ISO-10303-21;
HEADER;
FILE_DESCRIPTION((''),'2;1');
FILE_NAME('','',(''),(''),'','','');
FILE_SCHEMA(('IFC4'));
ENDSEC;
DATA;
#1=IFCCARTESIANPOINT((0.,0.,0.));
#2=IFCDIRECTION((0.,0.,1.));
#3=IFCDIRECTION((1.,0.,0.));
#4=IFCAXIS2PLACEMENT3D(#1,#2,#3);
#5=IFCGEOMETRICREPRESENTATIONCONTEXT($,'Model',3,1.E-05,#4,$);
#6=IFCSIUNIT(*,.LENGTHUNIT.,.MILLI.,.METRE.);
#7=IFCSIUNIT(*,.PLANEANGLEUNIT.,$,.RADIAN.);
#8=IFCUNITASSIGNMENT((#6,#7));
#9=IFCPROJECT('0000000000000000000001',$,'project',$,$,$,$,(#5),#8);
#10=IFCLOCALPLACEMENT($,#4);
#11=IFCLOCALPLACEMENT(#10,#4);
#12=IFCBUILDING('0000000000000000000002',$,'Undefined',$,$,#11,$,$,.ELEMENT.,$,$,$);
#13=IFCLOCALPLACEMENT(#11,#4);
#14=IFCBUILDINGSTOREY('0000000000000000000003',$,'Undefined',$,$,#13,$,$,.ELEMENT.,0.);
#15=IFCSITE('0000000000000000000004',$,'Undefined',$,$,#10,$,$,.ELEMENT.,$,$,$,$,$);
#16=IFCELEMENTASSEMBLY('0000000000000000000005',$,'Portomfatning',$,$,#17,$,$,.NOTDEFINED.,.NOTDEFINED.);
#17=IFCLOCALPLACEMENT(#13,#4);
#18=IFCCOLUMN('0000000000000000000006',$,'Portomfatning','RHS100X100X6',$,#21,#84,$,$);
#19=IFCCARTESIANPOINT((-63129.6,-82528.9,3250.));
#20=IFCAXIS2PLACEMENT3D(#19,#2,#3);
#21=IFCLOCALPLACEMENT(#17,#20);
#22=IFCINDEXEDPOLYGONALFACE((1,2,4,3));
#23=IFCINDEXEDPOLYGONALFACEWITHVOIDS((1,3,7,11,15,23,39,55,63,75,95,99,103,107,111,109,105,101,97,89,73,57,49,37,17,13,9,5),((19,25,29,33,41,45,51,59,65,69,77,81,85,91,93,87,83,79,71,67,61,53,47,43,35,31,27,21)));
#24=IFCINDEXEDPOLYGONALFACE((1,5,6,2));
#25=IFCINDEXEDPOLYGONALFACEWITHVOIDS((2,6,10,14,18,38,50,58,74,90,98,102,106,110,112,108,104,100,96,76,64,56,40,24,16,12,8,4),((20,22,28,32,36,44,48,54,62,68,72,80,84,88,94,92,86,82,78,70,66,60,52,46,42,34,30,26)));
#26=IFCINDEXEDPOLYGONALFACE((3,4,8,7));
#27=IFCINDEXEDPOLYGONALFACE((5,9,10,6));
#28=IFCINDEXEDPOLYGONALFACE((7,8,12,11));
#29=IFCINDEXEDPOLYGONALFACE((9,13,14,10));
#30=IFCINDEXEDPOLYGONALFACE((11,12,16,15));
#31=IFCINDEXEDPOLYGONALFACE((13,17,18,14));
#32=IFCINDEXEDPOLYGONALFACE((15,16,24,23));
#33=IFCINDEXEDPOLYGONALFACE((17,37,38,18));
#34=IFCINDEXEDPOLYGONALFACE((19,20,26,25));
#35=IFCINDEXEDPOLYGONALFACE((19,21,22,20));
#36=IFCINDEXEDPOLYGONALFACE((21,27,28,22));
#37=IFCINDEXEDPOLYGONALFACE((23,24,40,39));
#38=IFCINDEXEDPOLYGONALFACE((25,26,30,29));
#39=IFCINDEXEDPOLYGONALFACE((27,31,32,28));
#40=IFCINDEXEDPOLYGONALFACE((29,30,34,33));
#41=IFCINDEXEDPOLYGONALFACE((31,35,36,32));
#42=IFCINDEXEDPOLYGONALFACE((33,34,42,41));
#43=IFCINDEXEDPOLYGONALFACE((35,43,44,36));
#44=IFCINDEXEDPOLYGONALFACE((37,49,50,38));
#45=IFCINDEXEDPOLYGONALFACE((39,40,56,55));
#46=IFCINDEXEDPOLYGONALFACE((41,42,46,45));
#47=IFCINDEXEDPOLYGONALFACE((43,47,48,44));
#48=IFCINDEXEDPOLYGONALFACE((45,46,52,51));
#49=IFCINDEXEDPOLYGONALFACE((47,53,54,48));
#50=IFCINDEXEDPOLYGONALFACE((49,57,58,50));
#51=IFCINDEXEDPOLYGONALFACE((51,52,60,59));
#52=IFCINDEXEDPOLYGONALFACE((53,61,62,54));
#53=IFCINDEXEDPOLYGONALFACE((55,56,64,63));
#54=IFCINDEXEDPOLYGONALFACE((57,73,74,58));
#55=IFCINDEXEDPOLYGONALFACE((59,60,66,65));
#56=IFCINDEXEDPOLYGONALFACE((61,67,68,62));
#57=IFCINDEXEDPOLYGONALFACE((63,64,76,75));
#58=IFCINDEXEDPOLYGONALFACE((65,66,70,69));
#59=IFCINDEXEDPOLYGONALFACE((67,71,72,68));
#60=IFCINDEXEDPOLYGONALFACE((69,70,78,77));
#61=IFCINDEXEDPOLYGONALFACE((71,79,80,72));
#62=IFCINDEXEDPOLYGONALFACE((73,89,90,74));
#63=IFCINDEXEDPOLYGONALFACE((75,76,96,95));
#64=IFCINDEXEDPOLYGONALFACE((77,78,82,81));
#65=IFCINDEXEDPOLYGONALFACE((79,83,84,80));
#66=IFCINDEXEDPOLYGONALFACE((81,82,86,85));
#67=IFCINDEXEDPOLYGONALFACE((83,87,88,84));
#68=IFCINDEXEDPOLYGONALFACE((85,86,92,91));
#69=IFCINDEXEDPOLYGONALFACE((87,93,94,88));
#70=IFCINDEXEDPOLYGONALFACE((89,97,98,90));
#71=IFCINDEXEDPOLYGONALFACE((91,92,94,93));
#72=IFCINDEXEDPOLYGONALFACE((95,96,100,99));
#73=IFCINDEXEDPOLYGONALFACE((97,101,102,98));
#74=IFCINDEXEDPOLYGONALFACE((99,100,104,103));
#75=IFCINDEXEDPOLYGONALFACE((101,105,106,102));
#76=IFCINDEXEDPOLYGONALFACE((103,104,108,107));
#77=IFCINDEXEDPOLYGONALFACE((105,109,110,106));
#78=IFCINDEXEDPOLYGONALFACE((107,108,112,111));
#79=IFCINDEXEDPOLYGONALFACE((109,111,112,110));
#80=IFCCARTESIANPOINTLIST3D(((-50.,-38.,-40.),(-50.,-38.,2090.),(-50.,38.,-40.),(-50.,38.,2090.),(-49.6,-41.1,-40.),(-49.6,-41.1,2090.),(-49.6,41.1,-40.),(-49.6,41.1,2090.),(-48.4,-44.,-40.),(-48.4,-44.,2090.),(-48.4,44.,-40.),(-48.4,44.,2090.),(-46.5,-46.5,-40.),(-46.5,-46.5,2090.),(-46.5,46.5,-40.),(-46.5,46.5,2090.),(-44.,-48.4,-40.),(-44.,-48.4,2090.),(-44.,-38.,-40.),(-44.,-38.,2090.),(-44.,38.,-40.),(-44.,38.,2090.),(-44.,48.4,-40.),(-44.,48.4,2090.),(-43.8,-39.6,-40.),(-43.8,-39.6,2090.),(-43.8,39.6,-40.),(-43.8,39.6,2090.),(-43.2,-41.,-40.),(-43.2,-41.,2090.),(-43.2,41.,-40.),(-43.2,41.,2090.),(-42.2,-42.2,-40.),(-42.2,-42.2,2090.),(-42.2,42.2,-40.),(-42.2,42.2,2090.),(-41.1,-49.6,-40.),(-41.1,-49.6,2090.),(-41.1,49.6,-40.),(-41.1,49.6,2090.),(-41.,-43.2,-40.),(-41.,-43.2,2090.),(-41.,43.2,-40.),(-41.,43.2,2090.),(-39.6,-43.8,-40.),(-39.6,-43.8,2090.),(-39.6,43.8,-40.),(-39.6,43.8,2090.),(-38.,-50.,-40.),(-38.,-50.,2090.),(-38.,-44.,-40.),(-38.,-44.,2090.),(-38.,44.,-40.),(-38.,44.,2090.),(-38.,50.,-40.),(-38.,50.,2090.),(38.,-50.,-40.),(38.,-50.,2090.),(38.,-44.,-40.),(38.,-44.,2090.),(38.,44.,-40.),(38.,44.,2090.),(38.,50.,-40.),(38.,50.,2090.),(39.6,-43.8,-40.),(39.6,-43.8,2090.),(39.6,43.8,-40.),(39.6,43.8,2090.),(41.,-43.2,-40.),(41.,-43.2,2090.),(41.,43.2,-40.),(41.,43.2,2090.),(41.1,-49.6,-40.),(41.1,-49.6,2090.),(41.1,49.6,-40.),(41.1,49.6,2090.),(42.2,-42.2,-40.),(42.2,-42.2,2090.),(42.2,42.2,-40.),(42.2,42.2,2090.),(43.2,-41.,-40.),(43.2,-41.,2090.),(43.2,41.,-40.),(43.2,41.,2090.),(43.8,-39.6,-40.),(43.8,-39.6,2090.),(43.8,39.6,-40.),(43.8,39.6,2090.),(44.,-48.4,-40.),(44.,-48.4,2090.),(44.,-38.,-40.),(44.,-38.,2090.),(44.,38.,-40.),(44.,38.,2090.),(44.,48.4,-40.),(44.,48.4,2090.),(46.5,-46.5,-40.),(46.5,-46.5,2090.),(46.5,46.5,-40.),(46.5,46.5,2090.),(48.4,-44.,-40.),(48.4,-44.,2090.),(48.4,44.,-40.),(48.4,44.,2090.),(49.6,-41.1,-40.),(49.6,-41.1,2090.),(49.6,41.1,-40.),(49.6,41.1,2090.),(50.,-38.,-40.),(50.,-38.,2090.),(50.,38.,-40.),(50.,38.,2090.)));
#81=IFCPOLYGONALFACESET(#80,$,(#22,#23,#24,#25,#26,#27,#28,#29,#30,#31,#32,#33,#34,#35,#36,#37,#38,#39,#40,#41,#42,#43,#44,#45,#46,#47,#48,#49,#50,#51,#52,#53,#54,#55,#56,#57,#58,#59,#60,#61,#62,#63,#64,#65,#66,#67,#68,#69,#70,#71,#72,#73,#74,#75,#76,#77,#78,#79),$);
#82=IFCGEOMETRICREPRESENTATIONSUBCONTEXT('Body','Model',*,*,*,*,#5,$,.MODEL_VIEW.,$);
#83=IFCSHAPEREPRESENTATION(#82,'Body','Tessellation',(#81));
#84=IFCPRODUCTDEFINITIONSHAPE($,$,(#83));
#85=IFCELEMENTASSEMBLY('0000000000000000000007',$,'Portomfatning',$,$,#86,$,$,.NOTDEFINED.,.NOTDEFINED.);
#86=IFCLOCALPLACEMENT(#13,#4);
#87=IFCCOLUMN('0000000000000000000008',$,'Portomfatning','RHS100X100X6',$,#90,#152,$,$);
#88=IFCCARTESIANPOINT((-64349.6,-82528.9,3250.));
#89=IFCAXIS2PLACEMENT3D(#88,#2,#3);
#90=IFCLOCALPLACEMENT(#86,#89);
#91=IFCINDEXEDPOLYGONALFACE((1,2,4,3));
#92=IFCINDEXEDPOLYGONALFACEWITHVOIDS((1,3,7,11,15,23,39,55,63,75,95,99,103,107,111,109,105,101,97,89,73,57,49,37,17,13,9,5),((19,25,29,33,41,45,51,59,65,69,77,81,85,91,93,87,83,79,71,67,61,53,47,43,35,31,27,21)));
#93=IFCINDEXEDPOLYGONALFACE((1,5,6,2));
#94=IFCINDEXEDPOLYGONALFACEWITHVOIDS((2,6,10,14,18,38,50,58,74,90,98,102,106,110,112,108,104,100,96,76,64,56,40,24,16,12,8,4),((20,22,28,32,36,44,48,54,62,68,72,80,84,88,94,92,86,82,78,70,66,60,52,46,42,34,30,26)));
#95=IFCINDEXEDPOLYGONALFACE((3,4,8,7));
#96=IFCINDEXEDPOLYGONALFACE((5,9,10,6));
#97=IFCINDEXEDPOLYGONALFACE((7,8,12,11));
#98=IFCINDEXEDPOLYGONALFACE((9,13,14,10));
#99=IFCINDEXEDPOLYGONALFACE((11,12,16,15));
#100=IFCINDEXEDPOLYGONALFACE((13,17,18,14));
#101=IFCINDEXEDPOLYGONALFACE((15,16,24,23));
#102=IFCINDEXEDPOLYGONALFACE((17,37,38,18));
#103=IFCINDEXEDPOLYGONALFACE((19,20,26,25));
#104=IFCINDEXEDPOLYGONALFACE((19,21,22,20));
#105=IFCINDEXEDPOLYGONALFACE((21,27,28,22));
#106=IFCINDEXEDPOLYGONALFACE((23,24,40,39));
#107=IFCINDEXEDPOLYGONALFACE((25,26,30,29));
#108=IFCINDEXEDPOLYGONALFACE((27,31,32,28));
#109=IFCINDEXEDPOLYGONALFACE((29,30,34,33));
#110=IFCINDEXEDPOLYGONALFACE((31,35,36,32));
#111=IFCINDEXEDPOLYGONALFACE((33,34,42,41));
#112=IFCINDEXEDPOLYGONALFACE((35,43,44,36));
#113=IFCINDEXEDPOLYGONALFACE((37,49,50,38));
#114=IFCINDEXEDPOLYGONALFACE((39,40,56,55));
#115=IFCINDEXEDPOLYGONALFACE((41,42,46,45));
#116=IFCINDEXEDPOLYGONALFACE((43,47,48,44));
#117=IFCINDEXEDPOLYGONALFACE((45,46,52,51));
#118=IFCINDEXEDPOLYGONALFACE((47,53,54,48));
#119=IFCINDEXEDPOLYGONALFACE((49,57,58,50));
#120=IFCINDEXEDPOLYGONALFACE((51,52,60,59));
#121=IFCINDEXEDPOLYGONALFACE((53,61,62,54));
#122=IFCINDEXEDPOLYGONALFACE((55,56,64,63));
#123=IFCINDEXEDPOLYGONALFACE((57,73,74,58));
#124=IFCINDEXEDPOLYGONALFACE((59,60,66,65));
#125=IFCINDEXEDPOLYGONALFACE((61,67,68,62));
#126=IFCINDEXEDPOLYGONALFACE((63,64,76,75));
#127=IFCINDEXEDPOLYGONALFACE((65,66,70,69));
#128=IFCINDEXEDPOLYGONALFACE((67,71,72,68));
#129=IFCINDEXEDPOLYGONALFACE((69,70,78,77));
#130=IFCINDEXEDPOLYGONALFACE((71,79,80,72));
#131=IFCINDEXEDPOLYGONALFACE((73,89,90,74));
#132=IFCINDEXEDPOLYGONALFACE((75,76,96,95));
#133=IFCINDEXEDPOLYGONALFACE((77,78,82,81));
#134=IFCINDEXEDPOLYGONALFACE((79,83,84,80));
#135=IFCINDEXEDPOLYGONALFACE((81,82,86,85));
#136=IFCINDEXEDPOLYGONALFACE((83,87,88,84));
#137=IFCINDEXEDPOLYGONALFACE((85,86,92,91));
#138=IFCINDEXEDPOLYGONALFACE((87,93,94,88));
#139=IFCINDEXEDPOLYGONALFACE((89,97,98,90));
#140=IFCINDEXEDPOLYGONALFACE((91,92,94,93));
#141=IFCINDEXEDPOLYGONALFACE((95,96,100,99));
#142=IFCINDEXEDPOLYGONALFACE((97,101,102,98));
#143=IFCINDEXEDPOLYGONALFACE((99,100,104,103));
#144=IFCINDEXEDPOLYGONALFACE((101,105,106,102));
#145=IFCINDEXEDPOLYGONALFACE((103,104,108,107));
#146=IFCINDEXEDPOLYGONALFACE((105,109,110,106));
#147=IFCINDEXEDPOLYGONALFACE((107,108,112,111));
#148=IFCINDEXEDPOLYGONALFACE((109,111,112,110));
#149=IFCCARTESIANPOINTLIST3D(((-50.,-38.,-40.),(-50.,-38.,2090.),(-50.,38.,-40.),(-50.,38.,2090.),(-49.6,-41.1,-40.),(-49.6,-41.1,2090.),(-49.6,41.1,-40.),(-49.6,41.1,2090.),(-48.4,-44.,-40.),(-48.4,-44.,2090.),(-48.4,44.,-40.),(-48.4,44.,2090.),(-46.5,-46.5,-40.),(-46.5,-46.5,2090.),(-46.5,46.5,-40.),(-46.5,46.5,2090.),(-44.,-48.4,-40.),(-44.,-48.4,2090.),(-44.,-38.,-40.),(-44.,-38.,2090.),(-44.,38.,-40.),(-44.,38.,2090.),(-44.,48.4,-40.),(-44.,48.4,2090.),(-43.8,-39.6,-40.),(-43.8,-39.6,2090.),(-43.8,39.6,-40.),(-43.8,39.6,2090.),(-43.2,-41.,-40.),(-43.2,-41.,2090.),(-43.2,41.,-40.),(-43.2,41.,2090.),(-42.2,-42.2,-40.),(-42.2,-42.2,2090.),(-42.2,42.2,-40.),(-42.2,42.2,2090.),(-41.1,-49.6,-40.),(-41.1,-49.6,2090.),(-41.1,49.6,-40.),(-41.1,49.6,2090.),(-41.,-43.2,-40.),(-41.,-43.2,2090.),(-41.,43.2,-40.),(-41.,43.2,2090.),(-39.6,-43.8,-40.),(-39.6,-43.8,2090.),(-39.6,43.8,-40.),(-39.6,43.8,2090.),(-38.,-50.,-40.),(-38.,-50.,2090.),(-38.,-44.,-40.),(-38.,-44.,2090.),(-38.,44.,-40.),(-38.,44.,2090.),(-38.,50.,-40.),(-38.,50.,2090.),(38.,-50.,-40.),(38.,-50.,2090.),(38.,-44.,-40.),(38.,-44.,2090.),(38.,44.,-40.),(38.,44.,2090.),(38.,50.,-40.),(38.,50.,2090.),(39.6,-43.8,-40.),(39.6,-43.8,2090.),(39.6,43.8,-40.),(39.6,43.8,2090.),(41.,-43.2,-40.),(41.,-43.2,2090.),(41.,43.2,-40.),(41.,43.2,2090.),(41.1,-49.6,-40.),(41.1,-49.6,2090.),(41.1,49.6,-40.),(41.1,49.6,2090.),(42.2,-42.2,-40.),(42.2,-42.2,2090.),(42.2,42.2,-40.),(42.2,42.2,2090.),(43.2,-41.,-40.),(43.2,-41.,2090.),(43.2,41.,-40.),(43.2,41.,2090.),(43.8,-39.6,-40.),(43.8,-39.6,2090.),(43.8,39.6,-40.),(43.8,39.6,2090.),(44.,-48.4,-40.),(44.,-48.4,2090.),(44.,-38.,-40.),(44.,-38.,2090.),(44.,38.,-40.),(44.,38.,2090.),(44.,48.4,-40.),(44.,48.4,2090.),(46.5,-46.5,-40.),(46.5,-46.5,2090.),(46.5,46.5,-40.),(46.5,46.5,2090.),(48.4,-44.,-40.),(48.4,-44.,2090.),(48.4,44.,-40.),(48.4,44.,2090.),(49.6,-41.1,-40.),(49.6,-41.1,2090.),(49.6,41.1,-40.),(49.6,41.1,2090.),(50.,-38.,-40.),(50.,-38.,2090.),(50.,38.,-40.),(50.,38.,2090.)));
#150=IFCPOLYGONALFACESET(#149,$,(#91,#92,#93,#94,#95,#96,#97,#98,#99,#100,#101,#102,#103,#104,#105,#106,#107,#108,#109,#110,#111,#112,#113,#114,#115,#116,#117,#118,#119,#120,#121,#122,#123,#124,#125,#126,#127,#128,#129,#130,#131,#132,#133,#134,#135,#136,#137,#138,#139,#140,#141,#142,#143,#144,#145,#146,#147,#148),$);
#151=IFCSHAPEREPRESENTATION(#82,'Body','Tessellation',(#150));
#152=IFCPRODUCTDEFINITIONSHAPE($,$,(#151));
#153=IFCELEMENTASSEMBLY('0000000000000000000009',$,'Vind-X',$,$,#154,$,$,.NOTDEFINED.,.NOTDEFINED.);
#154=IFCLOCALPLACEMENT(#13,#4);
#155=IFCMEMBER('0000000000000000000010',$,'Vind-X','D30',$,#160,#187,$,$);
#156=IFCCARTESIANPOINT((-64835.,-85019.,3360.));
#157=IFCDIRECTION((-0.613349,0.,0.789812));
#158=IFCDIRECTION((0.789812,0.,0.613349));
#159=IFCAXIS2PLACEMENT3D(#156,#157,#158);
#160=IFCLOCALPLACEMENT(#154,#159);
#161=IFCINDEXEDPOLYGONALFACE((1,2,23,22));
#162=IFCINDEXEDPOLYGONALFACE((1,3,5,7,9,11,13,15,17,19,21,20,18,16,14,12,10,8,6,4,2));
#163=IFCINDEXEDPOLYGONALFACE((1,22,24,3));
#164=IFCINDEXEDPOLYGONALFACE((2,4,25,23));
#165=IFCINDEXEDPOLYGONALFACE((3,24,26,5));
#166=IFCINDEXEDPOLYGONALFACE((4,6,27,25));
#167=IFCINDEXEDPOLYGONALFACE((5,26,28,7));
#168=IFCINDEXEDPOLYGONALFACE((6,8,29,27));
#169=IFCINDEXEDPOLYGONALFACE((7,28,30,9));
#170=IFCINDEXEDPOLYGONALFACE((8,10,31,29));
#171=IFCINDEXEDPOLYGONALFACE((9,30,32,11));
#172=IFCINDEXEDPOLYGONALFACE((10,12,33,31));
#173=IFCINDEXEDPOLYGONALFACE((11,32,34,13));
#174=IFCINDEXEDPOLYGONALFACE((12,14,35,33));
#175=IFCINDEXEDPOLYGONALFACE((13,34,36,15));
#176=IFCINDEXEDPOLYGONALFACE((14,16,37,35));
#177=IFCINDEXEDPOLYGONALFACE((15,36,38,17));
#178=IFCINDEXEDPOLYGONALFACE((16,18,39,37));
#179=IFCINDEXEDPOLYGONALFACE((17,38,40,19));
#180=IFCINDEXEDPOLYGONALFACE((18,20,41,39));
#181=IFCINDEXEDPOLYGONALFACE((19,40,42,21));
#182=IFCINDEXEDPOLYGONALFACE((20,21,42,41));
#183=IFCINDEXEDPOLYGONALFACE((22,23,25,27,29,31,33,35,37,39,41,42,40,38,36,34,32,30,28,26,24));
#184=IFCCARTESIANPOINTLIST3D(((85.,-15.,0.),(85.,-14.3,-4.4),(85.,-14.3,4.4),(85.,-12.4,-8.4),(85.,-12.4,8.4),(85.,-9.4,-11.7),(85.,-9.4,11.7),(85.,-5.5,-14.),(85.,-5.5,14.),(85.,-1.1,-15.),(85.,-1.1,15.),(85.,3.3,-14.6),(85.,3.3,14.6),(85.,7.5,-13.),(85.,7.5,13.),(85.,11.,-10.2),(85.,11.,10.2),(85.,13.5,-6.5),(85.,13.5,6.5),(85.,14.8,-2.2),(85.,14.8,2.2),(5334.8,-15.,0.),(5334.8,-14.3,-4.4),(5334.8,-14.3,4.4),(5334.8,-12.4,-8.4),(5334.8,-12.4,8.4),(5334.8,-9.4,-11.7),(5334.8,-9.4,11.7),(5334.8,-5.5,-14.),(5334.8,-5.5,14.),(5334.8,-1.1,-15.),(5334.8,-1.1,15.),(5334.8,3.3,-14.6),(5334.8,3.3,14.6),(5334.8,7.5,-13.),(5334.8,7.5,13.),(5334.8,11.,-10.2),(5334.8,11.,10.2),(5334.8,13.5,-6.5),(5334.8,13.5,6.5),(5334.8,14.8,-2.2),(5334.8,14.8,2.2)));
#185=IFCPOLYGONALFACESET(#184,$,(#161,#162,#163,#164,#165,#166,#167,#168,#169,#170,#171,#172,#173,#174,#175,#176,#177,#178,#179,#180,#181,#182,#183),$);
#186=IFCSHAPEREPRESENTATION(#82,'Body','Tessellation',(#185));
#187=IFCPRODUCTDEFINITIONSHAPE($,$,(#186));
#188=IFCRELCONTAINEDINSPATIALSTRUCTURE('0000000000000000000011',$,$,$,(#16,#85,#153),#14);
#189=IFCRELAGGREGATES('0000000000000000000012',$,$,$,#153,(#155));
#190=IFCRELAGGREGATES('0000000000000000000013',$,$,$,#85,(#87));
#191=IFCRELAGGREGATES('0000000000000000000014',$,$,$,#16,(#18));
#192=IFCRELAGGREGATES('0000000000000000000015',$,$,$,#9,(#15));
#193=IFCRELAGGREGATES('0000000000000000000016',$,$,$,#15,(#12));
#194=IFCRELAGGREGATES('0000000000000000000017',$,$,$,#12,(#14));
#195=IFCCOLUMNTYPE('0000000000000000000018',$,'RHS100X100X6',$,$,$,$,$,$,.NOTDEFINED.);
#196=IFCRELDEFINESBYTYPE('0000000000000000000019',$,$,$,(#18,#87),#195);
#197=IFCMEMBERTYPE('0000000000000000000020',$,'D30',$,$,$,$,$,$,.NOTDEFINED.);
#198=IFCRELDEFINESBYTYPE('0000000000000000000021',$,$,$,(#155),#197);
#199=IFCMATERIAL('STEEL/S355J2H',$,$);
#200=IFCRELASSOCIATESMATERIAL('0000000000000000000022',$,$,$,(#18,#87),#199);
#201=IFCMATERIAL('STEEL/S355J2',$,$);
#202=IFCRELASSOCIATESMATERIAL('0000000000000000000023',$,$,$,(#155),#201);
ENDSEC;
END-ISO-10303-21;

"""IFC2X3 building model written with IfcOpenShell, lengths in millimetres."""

from ifc_helpers import new_model, si_unit, frame, origin_with_axes, origin_2d_with_axis, place, context, subcontext, project, spatial, hollow_rectangle, circle, extrude, clip, halfspace, material, type_object, element, aggregate, save


model = new_model("IFC2X3")

# Units and contexts
model_context = context("Model", 3, precision=1e-05, world=origin_with_axes())
body_context = subcontext(model_context, "Body", "Model", "MODEL_VIEW")
ifc_project = project(units=[si_unit("LENGTHUNIT", "METRE", prefix="MILLI"), si_unit("PLANEANGLEUNIT", "RADIAN")], contexts=[model_context])

# Site, building, storey
site_placement = place(None, origin_with_axes())
site = spatial("IfcSite", under=ifc_project, at=site_placement, Name="Undefined", CompositionType="ELEMENT")
building_placement = place(site_placement, origin_with_axes())
building = spatial("IfcBuilding", under=site, at=building_placement, Name="Undefined", CompositionType="ELEMENT")
storey_placement = place(building_placement, origin_with_axes())
storey = spatial("IfcBuildingStorey", under=building, at=storey_placement, Name="Undefined", CompositionType="ELEMENT", Elevation=0.0)

# Element assemblies, columns
assembly_1_placement = place(storey_placement, origin_with_axes())
assembly_1 = element("IfcElementAssembly", 1, at=assembly_1_placement, inside=storey, Name="Portomfatning", AssemblyPlace="NOTDEFINED", PredefinedType="NOTDEFINED")
ifc_material_1 = material(Name="STEEL/S355J2H")
column_type = type_object("IfcColumnType", Name="RHS100X100X6", PredefinedType="NOTDEFINED")
column_1_placement = place(assembly_1_placement, frame((-63129.6, -82528.9, 3250.0), z_axis=(0.0, 0.0, 1.0), x_axis=(1.0, 0.0, 0.0)))
column_1 = element("IfcColumn", 2, at=column_1_placement, type_object=column_type, material=ifc_material_1, Name="Portomfatning", Description="RHS100X100X6", context=body_context, shape_type="Clipping", body=[
    clip(clip(extrude(hollow_rectangle(XDim=100.0, YDim=100.0, WallThickness=6.0, InnerFilletRadius=6.0, OuterFilletRadius=12.0, at=origin_2d_with_axis()), frame((0.0, 0.0, 2100.0), z_axis=(0.0, 0.0, -1.0), x_axis=(0.0, 1.0, 0.0)), (0.0, 0.0, 1.0), 2140.0), halfspace(frame((-50.0, 0.0, 2090.0), z_axis=(0.0, 0.0, -1.0), x_axis=(0.0, -1.0, 0.0)), True)), halfspace(frame((0.0, 50.0, -40.0), z_axis=(0.0, 0.0, 1.0), x_axis=(1.0, 0.0, 0.0)), True)),
])
assembly_2_placement = place(storey_placement, origin_with_axes())
assembly_2 = element("IfcElementAssembly", 3, at=assembly_2_placement, inside=storey, Name="Portomfatning", AssemblyPlace="NOTDEFINED", PredefinedType="NOTDEFINED")
column_2_placement = place(assembly_2_placement, frame((-64349.6, -82528.9, 3250.0), z_axis=(0.0, 0.0, 1.0), x_axis=(1.0, 0.0, 0.0)))
column_2 = element("IfcColumn", 4, at=column_2_placement, type_object=column_type, material=ifc_material_1, Name="Portomfatning", Description="RHS100X100X6", context=body_context, shape_type="Clipping", body=[
    clip(clip(extrude(hollow_rectangle(XDim=100.0, YDim=100.0, WallThickness=6.0, InnerFilletRadius=6.0, OuterFilletRadius=12.0, at=origin_2d_with_axis()), frame((0.0, 0.0, 2100.0), z_axis=(0.0, 0.0, -1.0), x_axis=(0.0, 1.0, 0.0)), (0.0, 0.0, 1.0), 2140.0), halfspace(frame((50.0, 0.0, 2090.0), z_axis=(0.0, 0.0, -1.0), x_axis=(0.0, 1.0, 0.0)), True)), halfspace(frame((0.0, 50.0, -40.0), z_axis=(0.0, 0.0, 1.0), x_axis=(1.0, 0.0, 0.0)), True)),
])

# Element assembly, member
assembly_3_placement = place(storey_placement, origin_with_axes())
assembly_3 = element("IfcElementAssembly", 5, at=assembly_3_placement, inside=storey, Name="Vind-X", AssemblyPlace="NOTDEFINED", PredefinedType="NOTDEFINED")
ifc_material_2 = material(Name="STEEL/S355J2")
member_type_1 = type_object("IfcMemberType", Name="D30", PredefinedType="NOTDEFINED")
member_1_placement = place(assembly_3_placement, frame((-64835.0, -85019.0, 3360.0), z_axis=(-0.613349, 0.0, 0.789812), x_axis=(0.789812, 0.0, 0.613349)))
member_1 = element("IfcMember", 6, at=member_1_placement, type_object=member_type_1, material=ifc_material_2, Name="Vind-X", Description="D30", context=body_context, shape_type="Clipping", body=[
    clip(clip(extrude(circle(Radius=15.0, at=origin_2d_with_axis()), frame((5999.8, 0.0, 0.0), z_axis=(-1.0, 0.0, 0.0), x_axis=(0.0, -1.0, 0.0)), (0.0, 0.0, 1.0), 5999.9), halfspace(frame((5334.8, -6.0, 10.2), z_axis=(1.0, 0.0, 0.0), x_axis=(0.0, 1.0, 0.0)), False)), halfspace(frame((85.0, -6.0, 16.0), z_axis=(1.0, 0.0, 0.0), x_axis=(0.0, 1.0, 0.0)), True)),
])

aggregate(assembly_3, [member_1])

aggregate(assembly_2, [column_2])
aggregate(assembly_1, [column_1])

save(model, "model.ifc")
